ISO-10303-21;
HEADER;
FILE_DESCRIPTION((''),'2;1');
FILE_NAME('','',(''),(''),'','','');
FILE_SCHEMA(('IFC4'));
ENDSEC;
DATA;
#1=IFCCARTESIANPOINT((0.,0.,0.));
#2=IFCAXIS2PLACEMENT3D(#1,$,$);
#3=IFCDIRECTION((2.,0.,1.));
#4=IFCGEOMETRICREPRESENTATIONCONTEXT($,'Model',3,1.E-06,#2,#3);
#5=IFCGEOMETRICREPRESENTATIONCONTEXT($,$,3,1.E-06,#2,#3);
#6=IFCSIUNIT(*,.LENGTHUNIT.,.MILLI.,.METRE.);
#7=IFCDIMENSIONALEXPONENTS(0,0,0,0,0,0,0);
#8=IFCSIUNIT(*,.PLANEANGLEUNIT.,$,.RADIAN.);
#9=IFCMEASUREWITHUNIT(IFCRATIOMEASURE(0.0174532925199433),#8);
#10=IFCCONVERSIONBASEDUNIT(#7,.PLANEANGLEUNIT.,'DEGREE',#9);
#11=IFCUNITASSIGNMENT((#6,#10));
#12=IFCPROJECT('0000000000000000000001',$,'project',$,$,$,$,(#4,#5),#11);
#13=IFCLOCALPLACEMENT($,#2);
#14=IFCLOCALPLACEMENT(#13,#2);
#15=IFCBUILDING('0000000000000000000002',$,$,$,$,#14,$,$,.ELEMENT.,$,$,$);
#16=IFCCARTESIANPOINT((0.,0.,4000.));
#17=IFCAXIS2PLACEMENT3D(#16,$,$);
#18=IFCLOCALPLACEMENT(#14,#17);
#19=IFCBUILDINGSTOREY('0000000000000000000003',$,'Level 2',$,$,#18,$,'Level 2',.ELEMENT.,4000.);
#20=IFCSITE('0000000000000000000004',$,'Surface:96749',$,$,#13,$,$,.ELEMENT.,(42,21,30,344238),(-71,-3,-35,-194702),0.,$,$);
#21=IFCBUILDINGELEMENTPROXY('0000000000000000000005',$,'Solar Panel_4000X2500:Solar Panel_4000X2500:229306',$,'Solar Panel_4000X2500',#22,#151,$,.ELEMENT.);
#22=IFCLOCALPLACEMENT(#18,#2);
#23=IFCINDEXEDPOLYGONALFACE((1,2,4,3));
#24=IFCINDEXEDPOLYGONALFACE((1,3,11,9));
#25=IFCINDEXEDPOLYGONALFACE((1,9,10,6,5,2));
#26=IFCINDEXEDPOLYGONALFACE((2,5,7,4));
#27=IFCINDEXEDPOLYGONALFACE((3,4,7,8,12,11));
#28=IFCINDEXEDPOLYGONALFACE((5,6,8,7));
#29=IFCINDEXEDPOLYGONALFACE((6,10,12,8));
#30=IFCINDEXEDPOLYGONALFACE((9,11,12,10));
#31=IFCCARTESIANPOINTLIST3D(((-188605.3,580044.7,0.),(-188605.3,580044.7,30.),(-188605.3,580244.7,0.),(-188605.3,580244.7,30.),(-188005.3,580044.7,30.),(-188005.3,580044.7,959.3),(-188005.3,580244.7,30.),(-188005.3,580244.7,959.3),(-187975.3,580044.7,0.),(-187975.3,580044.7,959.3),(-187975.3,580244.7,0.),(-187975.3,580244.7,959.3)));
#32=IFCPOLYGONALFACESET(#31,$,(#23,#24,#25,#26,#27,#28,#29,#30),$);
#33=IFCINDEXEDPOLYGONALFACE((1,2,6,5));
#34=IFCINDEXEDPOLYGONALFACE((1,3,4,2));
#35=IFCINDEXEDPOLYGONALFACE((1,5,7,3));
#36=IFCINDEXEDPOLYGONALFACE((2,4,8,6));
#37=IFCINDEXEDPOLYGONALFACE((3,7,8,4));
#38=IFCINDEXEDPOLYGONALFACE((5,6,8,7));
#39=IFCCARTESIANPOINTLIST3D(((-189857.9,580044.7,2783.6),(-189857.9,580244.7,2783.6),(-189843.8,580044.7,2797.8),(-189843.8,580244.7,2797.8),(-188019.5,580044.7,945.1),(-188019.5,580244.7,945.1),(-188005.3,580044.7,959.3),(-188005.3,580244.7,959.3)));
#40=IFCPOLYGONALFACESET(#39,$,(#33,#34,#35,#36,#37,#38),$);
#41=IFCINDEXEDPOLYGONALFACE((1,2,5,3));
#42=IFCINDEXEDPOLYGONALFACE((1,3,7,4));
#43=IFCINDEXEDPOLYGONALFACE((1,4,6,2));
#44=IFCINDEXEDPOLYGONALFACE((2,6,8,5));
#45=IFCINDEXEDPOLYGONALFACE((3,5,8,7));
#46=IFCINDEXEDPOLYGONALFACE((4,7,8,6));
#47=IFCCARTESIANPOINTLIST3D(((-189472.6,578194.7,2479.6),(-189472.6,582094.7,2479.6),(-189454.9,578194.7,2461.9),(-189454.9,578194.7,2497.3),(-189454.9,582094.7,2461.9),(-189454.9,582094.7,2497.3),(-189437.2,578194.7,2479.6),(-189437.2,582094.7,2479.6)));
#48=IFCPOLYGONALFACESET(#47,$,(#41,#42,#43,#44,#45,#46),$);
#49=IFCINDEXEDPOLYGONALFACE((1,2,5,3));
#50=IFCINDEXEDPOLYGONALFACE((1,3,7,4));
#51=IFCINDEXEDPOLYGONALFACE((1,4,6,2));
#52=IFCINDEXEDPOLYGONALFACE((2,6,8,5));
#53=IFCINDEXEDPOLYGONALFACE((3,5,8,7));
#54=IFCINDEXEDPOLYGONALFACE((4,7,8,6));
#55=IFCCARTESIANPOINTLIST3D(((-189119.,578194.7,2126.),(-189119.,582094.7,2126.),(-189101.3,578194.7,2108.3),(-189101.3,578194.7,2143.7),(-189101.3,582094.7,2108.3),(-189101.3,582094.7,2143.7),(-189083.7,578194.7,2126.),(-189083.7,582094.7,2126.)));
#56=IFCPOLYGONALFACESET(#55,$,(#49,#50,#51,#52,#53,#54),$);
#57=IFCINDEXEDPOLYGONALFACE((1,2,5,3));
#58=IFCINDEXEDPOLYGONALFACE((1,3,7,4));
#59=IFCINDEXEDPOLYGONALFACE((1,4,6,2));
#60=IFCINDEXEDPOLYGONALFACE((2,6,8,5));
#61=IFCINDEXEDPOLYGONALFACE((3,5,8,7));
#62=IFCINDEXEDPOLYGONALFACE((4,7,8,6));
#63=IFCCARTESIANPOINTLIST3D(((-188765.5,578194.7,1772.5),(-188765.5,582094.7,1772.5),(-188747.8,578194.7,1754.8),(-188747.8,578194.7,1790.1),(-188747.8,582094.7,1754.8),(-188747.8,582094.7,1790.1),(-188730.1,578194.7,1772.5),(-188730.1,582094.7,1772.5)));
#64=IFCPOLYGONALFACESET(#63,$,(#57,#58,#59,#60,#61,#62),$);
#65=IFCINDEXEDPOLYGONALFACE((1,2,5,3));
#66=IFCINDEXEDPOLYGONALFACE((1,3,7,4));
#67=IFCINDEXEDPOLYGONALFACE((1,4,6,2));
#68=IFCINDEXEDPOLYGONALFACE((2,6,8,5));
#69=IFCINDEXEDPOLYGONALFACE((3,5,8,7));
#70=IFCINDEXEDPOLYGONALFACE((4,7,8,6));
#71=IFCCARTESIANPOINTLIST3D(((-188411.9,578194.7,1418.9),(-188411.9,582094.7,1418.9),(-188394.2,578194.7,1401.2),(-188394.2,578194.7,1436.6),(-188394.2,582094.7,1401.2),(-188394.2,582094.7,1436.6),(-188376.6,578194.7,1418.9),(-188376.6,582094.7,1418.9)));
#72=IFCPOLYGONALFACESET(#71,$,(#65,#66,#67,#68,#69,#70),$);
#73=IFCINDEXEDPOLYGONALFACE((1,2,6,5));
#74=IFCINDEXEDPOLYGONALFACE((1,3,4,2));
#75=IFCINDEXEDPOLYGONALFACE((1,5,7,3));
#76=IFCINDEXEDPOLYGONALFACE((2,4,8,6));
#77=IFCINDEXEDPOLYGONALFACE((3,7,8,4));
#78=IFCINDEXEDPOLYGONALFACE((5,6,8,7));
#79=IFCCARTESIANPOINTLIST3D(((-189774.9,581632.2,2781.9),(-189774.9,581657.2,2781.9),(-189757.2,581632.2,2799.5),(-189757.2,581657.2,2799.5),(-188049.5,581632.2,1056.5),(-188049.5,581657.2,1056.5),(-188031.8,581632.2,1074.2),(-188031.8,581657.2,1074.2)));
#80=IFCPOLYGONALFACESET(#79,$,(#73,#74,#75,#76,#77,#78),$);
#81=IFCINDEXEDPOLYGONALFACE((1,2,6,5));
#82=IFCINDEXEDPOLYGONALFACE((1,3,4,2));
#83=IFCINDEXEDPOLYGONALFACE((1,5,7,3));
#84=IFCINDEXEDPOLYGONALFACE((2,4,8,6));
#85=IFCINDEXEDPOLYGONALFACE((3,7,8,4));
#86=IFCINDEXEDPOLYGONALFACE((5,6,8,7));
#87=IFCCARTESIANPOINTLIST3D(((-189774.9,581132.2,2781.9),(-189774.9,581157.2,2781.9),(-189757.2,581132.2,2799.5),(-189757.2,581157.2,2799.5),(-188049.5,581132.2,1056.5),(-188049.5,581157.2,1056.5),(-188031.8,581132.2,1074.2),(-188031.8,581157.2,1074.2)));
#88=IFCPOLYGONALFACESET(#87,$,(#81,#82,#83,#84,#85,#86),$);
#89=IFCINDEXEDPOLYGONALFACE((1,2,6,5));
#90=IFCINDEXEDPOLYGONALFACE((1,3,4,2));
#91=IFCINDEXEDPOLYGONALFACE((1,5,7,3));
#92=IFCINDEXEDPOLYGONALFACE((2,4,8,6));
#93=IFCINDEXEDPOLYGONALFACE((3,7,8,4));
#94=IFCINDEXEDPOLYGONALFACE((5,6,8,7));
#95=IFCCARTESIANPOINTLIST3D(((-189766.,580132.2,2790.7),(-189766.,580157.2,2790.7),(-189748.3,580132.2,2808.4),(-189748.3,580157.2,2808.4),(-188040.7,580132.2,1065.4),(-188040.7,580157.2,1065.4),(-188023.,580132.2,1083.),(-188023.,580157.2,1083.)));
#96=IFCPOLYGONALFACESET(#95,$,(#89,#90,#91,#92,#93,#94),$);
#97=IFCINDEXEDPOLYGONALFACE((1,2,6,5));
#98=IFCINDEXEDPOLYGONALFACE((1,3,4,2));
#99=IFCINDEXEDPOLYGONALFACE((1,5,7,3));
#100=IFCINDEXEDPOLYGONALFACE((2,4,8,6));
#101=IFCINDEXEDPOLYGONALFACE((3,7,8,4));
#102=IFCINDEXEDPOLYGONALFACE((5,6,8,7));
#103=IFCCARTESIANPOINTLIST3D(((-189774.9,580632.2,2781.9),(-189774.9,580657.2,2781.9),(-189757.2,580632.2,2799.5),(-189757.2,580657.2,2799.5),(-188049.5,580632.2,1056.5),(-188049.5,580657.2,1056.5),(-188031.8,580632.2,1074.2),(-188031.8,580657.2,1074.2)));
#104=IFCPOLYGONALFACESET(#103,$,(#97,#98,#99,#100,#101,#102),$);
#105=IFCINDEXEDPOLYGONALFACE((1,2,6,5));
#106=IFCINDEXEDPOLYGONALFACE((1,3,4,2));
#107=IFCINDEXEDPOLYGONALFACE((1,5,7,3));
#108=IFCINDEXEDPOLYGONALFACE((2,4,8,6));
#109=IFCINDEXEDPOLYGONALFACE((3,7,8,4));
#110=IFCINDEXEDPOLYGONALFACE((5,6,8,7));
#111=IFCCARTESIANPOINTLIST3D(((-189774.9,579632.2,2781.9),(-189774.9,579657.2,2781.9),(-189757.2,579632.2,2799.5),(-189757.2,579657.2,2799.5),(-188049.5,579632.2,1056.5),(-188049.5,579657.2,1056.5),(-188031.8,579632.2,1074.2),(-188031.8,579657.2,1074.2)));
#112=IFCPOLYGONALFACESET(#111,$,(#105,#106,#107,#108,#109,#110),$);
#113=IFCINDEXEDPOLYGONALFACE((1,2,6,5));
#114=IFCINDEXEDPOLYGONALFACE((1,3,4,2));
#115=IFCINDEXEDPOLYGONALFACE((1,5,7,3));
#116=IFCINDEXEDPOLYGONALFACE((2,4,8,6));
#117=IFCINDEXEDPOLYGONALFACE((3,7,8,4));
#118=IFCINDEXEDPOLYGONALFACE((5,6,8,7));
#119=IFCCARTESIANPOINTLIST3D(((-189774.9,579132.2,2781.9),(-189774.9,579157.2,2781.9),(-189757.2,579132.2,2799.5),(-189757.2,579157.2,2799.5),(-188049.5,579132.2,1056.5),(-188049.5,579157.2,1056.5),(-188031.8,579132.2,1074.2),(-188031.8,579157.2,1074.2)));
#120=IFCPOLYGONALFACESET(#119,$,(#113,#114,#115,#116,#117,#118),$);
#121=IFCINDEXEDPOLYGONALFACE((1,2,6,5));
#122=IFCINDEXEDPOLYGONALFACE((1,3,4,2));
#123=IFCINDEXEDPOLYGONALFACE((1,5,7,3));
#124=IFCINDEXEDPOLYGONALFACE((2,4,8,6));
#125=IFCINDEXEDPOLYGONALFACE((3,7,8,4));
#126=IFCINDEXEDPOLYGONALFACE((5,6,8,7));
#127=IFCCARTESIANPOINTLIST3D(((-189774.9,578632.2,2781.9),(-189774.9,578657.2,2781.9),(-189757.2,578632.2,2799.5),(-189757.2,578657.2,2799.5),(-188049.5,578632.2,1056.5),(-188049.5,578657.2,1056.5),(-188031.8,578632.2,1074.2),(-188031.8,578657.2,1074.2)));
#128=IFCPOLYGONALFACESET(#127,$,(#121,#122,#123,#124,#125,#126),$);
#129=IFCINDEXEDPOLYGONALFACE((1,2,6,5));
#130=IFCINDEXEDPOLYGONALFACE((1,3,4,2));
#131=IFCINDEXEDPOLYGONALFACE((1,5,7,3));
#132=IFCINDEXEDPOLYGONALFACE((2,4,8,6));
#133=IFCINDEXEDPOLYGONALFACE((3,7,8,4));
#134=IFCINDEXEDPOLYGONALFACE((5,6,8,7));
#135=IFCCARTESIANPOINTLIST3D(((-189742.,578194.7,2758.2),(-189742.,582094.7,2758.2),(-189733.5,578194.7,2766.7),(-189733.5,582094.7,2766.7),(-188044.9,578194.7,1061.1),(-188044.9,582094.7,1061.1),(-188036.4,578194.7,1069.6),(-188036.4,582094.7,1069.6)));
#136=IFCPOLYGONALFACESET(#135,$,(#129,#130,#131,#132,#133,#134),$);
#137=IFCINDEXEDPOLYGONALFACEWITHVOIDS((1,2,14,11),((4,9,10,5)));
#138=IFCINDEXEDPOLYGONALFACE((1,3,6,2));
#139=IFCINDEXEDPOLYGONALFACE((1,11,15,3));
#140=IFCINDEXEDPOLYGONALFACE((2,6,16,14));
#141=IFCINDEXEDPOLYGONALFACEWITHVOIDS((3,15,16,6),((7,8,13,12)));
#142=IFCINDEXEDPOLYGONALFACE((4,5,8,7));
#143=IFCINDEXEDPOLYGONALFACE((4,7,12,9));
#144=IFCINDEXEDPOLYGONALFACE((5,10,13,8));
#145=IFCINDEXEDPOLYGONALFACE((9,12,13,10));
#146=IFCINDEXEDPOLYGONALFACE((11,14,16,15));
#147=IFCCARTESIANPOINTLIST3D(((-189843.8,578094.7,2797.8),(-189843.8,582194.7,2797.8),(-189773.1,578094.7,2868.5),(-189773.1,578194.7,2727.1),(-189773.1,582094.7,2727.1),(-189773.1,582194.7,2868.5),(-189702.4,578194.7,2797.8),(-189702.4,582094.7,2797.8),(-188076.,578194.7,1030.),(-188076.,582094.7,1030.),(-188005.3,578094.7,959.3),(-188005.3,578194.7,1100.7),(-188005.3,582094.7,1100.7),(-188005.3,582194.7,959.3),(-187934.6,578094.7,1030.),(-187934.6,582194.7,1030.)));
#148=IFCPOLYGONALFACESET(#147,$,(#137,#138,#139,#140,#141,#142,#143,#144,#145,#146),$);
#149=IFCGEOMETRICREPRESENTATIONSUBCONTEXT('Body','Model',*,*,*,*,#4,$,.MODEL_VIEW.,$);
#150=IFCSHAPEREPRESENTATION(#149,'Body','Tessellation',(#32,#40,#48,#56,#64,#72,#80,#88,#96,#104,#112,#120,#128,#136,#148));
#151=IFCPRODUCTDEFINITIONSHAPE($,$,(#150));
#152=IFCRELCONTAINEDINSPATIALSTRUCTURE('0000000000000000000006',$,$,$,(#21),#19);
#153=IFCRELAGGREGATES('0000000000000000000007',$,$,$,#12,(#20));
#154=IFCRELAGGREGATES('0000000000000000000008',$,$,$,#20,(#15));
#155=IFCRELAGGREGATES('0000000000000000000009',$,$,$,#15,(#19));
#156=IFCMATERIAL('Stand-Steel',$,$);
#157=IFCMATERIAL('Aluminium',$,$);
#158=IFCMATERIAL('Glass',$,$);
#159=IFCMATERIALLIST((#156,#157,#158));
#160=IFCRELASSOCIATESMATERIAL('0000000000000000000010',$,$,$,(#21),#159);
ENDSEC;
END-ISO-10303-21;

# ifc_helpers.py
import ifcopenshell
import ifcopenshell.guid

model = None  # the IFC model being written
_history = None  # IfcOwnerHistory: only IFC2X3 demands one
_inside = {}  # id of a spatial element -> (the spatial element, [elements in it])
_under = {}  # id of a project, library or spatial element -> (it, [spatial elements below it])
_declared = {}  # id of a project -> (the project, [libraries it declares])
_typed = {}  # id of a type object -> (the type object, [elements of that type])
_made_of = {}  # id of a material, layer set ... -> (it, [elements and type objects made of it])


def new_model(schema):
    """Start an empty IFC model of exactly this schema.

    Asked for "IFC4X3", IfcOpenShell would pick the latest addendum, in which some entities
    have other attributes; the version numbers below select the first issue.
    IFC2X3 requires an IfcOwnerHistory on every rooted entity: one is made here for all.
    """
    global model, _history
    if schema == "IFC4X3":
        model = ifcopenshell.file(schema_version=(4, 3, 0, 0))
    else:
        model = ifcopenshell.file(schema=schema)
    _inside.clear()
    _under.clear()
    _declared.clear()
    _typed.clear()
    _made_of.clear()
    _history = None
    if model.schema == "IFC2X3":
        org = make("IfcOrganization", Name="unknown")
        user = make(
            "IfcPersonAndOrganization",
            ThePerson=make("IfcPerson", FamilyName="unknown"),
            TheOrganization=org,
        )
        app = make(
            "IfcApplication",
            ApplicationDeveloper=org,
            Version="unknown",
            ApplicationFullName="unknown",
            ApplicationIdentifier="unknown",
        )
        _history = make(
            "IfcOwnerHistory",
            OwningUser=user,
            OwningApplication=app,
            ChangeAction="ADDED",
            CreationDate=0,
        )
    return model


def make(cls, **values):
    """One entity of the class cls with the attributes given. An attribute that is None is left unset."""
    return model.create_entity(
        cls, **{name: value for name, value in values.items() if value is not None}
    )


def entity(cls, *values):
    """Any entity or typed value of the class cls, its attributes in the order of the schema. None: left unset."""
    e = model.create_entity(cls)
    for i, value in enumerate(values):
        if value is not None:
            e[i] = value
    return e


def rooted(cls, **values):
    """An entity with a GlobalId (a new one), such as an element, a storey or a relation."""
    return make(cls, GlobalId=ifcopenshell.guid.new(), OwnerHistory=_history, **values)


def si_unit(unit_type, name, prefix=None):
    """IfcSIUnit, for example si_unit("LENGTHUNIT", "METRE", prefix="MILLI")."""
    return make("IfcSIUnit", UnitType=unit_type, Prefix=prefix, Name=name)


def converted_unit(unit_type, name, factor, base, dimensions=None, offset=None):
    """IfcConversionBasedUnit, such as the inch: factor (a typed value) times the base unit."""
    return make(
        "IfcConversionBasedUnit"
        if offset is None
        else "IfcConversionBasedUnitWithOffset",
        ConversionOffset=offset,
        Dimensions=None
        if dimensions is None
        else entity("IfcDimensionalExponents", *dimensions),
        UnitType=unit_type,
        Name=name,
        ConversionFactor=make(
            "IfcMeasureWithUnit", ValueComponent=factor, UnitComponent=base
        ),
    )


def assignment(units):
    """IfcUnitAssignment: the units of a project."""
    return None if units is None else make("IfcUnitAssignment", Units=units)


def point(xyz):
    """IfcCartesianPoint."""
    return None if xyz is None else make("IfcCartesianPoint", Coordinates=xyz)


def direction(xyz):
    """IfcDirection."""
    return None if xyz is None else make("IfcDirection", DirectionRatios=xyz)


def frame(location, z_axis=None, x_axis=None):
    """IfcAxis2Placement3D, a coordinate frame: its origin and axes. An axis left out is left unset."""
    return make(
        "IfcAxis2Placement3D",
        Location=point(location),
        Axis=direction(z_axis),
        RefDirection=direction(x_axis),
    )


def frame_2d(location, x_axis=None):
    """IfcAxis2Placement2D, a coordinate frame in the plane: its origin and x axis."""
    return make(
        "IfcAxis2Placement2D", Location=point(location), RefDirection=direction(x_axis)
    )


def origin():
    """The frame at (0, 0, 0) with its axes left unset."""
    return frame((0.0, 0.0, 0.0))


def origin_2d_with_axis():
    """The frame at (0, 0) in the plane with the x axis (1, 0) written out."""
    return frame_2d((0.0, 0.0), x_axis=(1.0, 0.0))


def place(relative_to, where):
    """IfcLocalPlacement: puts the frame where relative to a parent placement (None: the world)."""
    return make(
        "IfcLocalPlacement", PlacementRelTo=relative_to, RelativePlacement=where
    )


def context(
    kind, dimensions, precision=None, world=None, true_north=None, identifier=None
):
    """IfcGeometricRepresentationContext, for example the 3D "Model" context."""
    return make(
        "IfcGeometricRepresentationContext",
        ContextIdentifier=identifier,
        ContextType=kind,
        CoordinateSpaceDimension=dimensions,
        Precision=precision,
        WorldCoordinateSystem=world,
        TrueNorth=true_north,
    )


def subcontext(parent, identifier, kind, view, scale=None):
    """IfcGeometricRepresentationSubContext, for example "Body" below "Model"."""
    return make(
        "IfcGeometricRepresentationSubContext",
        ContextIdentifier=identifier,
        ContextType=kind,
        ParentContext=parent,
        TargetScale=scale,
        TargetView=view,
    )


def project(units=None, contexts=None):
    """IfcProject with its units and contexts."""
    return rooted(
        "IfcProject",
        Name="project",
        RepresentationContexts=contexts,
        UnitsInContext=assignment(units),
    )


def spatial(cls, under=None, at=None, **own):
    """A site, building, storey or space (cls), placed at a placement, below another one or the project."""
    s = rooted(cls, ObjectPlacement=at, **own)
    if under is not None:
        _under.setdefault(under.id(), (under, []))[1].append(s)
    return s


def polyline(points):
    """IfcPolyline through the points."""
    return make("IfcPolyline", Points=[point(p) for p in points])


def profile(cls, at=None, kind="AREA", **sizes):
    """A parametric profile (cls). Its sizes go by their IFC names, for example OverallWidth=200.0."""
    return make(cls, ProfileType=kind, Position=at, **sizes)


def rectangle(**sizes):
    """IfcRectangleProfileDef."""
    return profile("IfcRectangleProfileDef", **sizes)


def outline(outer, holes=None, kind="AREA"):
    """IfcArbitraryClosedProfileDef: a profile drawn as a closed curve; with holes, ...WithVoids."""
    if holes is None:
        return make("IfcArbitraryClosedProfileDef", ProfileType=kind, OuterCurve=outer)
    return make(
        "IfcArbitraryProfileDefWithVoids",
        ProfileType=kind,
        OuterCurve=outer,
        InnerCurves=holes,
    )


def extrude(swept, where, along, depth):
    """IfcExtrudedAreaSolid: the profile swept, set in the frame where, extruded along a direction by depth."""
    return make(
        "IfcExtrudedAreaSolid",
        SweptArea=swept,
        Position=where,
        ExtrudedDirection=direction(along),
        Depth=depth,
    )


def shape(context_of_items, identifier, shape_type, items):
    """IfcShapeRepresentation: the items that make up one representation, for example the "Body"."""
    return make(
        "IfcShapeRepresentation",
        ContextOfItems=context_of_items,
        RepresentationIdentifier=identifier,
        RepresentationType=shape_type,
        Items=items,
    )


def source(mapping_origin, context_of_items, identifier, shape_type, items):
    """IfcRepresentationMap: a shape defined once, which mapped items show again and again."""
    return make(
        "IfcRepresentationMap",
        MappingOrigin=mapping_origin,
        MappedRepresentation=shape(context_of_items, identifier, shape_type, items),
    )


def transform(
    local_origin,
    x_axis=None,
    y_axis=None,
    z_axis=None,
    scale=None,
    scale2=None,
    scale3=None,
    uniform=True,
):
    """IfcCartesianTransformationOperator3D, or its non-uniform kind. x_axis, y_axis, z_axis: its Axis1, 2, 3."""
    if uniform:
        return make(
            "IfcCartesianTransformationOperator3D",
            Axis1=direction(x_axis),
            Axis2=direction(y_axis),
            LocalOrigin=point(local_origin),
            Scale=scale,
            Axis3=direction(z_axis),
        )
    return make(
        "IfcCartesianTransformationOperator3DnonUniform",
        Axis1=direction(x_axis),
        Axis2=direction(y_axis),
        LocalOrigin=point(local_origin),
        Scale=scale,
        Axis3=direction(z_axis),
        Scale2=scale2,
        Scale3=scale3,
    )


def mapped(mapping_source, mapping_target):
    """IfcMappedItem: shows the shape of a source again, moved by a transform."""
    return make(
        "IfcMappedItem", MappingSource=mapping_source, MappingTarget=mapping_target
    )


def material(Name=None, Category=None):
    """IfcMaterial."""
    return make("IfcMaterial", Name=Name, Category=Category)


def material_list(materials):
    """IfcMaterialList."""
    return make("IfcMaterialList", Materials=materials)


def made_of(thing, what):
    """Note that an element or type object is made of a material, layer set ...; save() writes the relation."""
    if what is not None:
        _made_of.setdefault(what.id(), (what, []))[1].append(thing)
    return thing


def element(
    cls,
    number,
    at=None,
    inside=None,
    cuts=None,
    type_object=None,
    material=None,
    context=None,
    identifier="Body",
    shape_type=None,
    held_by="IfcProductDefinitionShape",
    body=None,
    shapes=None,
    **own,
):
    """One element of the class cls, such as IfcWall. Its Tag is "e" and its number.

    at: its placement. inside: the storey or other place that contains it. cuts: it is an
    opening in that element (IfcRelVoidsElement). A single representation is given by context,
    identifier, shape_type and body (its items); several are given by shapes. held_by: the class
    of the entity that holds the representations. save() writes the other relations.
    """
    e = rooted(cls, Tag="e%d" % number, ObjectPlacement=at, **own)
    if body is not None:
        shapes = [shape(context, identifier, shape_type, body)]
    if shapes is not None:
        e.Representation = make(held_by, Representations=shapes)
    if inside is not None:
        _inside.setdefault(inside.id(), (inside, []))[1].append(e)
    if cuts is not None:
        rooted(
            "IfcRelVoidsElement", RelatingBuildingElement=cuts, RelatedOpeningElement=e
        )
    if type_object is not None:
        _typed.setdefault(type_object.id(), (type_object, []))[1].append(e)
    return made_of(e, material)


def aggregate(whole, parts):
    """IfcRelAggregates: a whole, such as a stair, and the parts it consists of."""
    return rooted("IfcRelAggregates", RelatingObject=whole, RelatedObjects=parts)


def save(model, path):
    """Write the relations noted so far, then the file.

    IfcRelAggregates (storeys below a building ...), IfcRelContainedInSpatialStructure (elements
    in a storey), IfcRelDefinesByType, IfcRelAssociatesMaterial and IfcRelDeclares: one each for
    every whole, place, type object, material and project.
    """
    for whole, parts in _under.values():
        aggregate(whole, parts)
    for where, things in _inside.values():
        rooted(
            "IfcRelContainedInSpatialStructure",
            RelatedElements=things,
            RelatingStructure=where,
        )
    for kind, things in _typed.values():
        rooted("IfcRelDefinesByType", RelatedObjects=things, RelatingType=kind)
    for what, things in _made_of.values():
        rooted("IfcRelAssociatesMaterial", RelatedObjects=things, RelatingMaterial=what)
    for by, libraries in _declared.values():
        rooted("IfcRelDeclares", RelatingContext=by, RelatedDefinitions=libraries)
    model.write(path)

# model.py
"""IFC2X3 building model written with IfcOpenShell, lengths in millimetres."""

from ifc_helpers import new_model, entity, si_unit, converted_unit, direction, frame, frame_2d, origin, origin_2d_with_axis, place, context, subcontext, project, spatial, polyline, rectangle, outline, extrude, source, transform, mapped, material, material_list, element, save


model = new_model("IFC2X3")

# Units and contexts
model_context = context("Model", 3, precision=1e-06, world=origin(), true_north=direction((2.0, 0.0, 1.0)))
context_of_model = context(None, 3, precision=1e-06, world=origin(), true_north=direction((2.0, 0.0, 1.0)))
body_context = subcontext(model_context, "Body", "Model", "MODEL_VIEW")
ifc_project = project(units=[si_unit("LENGTHUNIT", "METRE", prefix="MILLI"), converted_unit("PLANEANGLEUNIT", "DEGREE", entity("IfcRatioMeasure", 0.0174532925199433), si_unit("PLANEANGLEUNIT", "RADIAN"), dimensions=[0, 0, 0, 0, 0, 0, 0])], contexts=[model_context, context_of_model])

# Site, building, storey
site_placement = place(None, origin())
site = spatial("IfcSite", under=ifc_project, at=site_placement, Name="Surface:96749", CompositionType="ELEMENT", RefLatitude=(42, 21, 30, 344238), RefLongitude=(-71, -3, -35, -194702), RefElevation=0.0)
building_placement = place(site_placement, origin())
building = spatial("IfcBuilding", under=site, at=building_placement, CompositionType="ELEMENT")
storey_placement = place(building_placement, frame((0.0, 0.0, 4000.0)))
storey = spatial("IfcBuildingStorey", under=building, at=storey_placement, Name="Level 2", LongName="Level 2", CompositionType="ELEMENT", Elevation=4000.0)

# Building element proxy
ifc_material_1 = material(Name="Stand-Steel")
ifc_material_2 = material(Name="Aluminium")
ifc_material_3 = material(Name="Glass")
shared_shape = source(origin(), body_context, "Body", "SweptSolid", [
    extrude(outline(polyline([(-629.5, -220.0), (329.8, -220.0), (329.8, 410.0), (299.8, 410.0), (299.8, -190.0), (-629.5, -190.0), (-629.5, -220.0)])), frame((-190.0, -100.0, 299.8), z_axis=(0.0, 1.0, 0.0), x_axis=(0.0, 0.0, -1.0)), (0.0, 0.0, 1.0), 200.0),
    extrude(rectangle(XDim=20.0, YDim=200.0, at=frame_2d((0.0, 0.0), x_axis=(0.0, 1.0))), frame((-7.1, 0.0, 922.2), z_axis=(-0.707107, 0.0, 0.707107), x_axis=(0.0, 1.0, 0.0)), (0.0, 0.0, 1.0), 2600.0),
    extrude(rectangle(XDim=25.0, YDim=25.0, at=frame_2d((0.0, 0.0), x_axis=(1.0, 0.0))), frame((-1449.6, -1950.0, 2449.6), z_axis=(0.0, 1.0, 0.0), x_axis=(-0.707107, 0.0, -0.707107)), (0.0, 0.0, 1.0), 3900.0),
    extrude(rectangle(XDim=25.0, YDim=25.0, at=origin_2d_with_axis()), frame((-1096.0, -1950.0, 2096.0), z_axis=(0.0, 1.0, 0.0), x_axis=(-0.707107, 0.0, -0.707107)), (0.0, 0.0, 1.0), 3900.0),
    extrude(rectangle(XDim=25.0, YDim=25.0, at=origin_2d_with_axis()), frame((-742.5, -1950.0, 1742.5), z_axis=(0.0, 1.0, 0.0), x_axis=(-0.707107, 0.0, -0.707107)), (0.0, 0.0, 1.0), 3900.0),
    extrude(rectangle(XDim=25.0, YDim=25.0, at=frame_2d((0.0, 0.0), x_axis=(1.0, 0.0))), frame((-388.9, -1950.0, 1388.9), z_axis=(0.0, 1.0, 0.0), x_axis=(-0.707107, 0.0, -0.707107)), (0.0, 0.0, 1.0), 3900.0),
    extrude(rectangle(XDim=25.0, YDim=25.0, at=frame_2d((0.0, 0.0), x_axis=(0.0, 1.0))), frame((-35.4, 1500.0, 1035.4), z_axis=(-0.707107, 0.0, 0.707107), x_axis=(0.0, 1.0, 0.0)), (0.0, 0.0, 1.0), 2440.0),
    extrude(rectangle(XDim=25.0, YDim=25.0, at=frame_2d((0.0, 0.0), x_axis=(0.0, 1.0))), frame((-35.4, 1000.0, 1035.4), z_axis=(-0.707107, 0.0, 0.707107), x_axis=(0.0, 1.0, 0.0)), (0.0, 0.0, 1.0), 2440.0),
    extrude(rectangle(XDim=25.0, YDim=25.0, at=frame_2d((0.0, 0.0), x_axis=(0.0, 1.0))), frame((-26.5, 0.0, 1044.2), z_axis=(-0.707107, 0.0, 0.707107), x_axis=(0.0, -1.0, 0.0)), (0.0, 0.0, 1.0), 2440.0),
    extrude(rectangle(XDim=25.0, YDim=25.0, at=frame_2d((0.0, 0.0), x_axis=(0.0, 1.0))), frame((-35.4, 500.0, 1035.4), z_axis=(-0.707107, 0.0, 0.707107), x_axis=(0.0, 1.0, 0.0)), (0.0, 0.0, 1.0), 2440.0),
    extrude(rectangle(XDim=25.0, YDim=25.0, at=frame_2d((0.0, 0.0), x_axis=(0.0, 1.0))), frame((-35.4, -500.0, 1035.4), z_axis=(-0.707107, 0.0, 0.707107), x_axis=(0.0, 1.0, 0.0)), (0.0, 0.0, 1.0), 2440.0),
    extrude(rectangle(XDim=25.0, YDim=25.0, at=frame_2d((0.0, 0.0), x_axis=(0.0, 1.0))), frame((-35.4, -1000.0, 1035.4), z_axis=(-0.707107, 0.0, 0.707107), x_axis=(0.0, 1.0, 0.0)), (0.0, 0.0, 1.0), 2440.0),
    extrude(rectangle(XDim=25.0, YDim=25.0, at=frame_2d((0.0, 0.0), x_axis=(0.0, 1.0))), frame((-35.4, -1500.0, 1035.4), z_axis=(-0.707107, 0.0, 0.707107), x_axis=(0.0, 1.0, 0.0)), (0.0, 0.0, 1.0), 2440.0),
    extrude(rectangle(XDim=2400.0, YDim=12.0, at=frame_2d((0.0, 0.0), x_axis=(1.0, 0.0))), frame((-883.9, -1950.0, 1883.9), z_axis=(0.0, 1.0, 0.0), x_axis=(0.707107, 0.0, -0.707107)), (0.0, 0.0, 1.0), 3900.0),
    extrude(outline(polyline([(-2050.0, -1300.0), (2050.0, -1300.0), (2050.0, 1300.0), (-2050.0, 1300.0), (-2050.0, -1300.0)]), holes=[polyline([(1950.0, -1200.0), (-1950.0, -1200.0), (-1950.0, 1200.0), (1950.0, 1200.0), (1950.0, -1200.0)])]), frame((-919.2, 0.0, 1848.5), z_axis=(0.707107, 0.0, 0.707107), x_axis=(0.0, 1.0, 0.0)), (0.0, 0.0, 1.0), 100.0),
])
ifc_material_list_1 = material_list([ifc_material_1, ifc_material_2, ifc_material_3])
proxy_1_placement = place(storey_placement, frame((-188005.3, 580144.7, 30.0)))
element("IfcBuildingElementProxy", 1, at=proxy_1_placement, inside=storey, material=ifc_material_list_1, Name="Solar Panel_4000X2500:Solar Panel_4000X2500:229306", ObjectType="Solar Panel_4000X2500", CompositionType="ELEMENT", context=body_context, shape_type="MappedRepresentation", body=[
    mapped(shared_shape, transform((0.0, 0.0, 0.0), scale=1.0)),
])

save(model, "model.ifc")
